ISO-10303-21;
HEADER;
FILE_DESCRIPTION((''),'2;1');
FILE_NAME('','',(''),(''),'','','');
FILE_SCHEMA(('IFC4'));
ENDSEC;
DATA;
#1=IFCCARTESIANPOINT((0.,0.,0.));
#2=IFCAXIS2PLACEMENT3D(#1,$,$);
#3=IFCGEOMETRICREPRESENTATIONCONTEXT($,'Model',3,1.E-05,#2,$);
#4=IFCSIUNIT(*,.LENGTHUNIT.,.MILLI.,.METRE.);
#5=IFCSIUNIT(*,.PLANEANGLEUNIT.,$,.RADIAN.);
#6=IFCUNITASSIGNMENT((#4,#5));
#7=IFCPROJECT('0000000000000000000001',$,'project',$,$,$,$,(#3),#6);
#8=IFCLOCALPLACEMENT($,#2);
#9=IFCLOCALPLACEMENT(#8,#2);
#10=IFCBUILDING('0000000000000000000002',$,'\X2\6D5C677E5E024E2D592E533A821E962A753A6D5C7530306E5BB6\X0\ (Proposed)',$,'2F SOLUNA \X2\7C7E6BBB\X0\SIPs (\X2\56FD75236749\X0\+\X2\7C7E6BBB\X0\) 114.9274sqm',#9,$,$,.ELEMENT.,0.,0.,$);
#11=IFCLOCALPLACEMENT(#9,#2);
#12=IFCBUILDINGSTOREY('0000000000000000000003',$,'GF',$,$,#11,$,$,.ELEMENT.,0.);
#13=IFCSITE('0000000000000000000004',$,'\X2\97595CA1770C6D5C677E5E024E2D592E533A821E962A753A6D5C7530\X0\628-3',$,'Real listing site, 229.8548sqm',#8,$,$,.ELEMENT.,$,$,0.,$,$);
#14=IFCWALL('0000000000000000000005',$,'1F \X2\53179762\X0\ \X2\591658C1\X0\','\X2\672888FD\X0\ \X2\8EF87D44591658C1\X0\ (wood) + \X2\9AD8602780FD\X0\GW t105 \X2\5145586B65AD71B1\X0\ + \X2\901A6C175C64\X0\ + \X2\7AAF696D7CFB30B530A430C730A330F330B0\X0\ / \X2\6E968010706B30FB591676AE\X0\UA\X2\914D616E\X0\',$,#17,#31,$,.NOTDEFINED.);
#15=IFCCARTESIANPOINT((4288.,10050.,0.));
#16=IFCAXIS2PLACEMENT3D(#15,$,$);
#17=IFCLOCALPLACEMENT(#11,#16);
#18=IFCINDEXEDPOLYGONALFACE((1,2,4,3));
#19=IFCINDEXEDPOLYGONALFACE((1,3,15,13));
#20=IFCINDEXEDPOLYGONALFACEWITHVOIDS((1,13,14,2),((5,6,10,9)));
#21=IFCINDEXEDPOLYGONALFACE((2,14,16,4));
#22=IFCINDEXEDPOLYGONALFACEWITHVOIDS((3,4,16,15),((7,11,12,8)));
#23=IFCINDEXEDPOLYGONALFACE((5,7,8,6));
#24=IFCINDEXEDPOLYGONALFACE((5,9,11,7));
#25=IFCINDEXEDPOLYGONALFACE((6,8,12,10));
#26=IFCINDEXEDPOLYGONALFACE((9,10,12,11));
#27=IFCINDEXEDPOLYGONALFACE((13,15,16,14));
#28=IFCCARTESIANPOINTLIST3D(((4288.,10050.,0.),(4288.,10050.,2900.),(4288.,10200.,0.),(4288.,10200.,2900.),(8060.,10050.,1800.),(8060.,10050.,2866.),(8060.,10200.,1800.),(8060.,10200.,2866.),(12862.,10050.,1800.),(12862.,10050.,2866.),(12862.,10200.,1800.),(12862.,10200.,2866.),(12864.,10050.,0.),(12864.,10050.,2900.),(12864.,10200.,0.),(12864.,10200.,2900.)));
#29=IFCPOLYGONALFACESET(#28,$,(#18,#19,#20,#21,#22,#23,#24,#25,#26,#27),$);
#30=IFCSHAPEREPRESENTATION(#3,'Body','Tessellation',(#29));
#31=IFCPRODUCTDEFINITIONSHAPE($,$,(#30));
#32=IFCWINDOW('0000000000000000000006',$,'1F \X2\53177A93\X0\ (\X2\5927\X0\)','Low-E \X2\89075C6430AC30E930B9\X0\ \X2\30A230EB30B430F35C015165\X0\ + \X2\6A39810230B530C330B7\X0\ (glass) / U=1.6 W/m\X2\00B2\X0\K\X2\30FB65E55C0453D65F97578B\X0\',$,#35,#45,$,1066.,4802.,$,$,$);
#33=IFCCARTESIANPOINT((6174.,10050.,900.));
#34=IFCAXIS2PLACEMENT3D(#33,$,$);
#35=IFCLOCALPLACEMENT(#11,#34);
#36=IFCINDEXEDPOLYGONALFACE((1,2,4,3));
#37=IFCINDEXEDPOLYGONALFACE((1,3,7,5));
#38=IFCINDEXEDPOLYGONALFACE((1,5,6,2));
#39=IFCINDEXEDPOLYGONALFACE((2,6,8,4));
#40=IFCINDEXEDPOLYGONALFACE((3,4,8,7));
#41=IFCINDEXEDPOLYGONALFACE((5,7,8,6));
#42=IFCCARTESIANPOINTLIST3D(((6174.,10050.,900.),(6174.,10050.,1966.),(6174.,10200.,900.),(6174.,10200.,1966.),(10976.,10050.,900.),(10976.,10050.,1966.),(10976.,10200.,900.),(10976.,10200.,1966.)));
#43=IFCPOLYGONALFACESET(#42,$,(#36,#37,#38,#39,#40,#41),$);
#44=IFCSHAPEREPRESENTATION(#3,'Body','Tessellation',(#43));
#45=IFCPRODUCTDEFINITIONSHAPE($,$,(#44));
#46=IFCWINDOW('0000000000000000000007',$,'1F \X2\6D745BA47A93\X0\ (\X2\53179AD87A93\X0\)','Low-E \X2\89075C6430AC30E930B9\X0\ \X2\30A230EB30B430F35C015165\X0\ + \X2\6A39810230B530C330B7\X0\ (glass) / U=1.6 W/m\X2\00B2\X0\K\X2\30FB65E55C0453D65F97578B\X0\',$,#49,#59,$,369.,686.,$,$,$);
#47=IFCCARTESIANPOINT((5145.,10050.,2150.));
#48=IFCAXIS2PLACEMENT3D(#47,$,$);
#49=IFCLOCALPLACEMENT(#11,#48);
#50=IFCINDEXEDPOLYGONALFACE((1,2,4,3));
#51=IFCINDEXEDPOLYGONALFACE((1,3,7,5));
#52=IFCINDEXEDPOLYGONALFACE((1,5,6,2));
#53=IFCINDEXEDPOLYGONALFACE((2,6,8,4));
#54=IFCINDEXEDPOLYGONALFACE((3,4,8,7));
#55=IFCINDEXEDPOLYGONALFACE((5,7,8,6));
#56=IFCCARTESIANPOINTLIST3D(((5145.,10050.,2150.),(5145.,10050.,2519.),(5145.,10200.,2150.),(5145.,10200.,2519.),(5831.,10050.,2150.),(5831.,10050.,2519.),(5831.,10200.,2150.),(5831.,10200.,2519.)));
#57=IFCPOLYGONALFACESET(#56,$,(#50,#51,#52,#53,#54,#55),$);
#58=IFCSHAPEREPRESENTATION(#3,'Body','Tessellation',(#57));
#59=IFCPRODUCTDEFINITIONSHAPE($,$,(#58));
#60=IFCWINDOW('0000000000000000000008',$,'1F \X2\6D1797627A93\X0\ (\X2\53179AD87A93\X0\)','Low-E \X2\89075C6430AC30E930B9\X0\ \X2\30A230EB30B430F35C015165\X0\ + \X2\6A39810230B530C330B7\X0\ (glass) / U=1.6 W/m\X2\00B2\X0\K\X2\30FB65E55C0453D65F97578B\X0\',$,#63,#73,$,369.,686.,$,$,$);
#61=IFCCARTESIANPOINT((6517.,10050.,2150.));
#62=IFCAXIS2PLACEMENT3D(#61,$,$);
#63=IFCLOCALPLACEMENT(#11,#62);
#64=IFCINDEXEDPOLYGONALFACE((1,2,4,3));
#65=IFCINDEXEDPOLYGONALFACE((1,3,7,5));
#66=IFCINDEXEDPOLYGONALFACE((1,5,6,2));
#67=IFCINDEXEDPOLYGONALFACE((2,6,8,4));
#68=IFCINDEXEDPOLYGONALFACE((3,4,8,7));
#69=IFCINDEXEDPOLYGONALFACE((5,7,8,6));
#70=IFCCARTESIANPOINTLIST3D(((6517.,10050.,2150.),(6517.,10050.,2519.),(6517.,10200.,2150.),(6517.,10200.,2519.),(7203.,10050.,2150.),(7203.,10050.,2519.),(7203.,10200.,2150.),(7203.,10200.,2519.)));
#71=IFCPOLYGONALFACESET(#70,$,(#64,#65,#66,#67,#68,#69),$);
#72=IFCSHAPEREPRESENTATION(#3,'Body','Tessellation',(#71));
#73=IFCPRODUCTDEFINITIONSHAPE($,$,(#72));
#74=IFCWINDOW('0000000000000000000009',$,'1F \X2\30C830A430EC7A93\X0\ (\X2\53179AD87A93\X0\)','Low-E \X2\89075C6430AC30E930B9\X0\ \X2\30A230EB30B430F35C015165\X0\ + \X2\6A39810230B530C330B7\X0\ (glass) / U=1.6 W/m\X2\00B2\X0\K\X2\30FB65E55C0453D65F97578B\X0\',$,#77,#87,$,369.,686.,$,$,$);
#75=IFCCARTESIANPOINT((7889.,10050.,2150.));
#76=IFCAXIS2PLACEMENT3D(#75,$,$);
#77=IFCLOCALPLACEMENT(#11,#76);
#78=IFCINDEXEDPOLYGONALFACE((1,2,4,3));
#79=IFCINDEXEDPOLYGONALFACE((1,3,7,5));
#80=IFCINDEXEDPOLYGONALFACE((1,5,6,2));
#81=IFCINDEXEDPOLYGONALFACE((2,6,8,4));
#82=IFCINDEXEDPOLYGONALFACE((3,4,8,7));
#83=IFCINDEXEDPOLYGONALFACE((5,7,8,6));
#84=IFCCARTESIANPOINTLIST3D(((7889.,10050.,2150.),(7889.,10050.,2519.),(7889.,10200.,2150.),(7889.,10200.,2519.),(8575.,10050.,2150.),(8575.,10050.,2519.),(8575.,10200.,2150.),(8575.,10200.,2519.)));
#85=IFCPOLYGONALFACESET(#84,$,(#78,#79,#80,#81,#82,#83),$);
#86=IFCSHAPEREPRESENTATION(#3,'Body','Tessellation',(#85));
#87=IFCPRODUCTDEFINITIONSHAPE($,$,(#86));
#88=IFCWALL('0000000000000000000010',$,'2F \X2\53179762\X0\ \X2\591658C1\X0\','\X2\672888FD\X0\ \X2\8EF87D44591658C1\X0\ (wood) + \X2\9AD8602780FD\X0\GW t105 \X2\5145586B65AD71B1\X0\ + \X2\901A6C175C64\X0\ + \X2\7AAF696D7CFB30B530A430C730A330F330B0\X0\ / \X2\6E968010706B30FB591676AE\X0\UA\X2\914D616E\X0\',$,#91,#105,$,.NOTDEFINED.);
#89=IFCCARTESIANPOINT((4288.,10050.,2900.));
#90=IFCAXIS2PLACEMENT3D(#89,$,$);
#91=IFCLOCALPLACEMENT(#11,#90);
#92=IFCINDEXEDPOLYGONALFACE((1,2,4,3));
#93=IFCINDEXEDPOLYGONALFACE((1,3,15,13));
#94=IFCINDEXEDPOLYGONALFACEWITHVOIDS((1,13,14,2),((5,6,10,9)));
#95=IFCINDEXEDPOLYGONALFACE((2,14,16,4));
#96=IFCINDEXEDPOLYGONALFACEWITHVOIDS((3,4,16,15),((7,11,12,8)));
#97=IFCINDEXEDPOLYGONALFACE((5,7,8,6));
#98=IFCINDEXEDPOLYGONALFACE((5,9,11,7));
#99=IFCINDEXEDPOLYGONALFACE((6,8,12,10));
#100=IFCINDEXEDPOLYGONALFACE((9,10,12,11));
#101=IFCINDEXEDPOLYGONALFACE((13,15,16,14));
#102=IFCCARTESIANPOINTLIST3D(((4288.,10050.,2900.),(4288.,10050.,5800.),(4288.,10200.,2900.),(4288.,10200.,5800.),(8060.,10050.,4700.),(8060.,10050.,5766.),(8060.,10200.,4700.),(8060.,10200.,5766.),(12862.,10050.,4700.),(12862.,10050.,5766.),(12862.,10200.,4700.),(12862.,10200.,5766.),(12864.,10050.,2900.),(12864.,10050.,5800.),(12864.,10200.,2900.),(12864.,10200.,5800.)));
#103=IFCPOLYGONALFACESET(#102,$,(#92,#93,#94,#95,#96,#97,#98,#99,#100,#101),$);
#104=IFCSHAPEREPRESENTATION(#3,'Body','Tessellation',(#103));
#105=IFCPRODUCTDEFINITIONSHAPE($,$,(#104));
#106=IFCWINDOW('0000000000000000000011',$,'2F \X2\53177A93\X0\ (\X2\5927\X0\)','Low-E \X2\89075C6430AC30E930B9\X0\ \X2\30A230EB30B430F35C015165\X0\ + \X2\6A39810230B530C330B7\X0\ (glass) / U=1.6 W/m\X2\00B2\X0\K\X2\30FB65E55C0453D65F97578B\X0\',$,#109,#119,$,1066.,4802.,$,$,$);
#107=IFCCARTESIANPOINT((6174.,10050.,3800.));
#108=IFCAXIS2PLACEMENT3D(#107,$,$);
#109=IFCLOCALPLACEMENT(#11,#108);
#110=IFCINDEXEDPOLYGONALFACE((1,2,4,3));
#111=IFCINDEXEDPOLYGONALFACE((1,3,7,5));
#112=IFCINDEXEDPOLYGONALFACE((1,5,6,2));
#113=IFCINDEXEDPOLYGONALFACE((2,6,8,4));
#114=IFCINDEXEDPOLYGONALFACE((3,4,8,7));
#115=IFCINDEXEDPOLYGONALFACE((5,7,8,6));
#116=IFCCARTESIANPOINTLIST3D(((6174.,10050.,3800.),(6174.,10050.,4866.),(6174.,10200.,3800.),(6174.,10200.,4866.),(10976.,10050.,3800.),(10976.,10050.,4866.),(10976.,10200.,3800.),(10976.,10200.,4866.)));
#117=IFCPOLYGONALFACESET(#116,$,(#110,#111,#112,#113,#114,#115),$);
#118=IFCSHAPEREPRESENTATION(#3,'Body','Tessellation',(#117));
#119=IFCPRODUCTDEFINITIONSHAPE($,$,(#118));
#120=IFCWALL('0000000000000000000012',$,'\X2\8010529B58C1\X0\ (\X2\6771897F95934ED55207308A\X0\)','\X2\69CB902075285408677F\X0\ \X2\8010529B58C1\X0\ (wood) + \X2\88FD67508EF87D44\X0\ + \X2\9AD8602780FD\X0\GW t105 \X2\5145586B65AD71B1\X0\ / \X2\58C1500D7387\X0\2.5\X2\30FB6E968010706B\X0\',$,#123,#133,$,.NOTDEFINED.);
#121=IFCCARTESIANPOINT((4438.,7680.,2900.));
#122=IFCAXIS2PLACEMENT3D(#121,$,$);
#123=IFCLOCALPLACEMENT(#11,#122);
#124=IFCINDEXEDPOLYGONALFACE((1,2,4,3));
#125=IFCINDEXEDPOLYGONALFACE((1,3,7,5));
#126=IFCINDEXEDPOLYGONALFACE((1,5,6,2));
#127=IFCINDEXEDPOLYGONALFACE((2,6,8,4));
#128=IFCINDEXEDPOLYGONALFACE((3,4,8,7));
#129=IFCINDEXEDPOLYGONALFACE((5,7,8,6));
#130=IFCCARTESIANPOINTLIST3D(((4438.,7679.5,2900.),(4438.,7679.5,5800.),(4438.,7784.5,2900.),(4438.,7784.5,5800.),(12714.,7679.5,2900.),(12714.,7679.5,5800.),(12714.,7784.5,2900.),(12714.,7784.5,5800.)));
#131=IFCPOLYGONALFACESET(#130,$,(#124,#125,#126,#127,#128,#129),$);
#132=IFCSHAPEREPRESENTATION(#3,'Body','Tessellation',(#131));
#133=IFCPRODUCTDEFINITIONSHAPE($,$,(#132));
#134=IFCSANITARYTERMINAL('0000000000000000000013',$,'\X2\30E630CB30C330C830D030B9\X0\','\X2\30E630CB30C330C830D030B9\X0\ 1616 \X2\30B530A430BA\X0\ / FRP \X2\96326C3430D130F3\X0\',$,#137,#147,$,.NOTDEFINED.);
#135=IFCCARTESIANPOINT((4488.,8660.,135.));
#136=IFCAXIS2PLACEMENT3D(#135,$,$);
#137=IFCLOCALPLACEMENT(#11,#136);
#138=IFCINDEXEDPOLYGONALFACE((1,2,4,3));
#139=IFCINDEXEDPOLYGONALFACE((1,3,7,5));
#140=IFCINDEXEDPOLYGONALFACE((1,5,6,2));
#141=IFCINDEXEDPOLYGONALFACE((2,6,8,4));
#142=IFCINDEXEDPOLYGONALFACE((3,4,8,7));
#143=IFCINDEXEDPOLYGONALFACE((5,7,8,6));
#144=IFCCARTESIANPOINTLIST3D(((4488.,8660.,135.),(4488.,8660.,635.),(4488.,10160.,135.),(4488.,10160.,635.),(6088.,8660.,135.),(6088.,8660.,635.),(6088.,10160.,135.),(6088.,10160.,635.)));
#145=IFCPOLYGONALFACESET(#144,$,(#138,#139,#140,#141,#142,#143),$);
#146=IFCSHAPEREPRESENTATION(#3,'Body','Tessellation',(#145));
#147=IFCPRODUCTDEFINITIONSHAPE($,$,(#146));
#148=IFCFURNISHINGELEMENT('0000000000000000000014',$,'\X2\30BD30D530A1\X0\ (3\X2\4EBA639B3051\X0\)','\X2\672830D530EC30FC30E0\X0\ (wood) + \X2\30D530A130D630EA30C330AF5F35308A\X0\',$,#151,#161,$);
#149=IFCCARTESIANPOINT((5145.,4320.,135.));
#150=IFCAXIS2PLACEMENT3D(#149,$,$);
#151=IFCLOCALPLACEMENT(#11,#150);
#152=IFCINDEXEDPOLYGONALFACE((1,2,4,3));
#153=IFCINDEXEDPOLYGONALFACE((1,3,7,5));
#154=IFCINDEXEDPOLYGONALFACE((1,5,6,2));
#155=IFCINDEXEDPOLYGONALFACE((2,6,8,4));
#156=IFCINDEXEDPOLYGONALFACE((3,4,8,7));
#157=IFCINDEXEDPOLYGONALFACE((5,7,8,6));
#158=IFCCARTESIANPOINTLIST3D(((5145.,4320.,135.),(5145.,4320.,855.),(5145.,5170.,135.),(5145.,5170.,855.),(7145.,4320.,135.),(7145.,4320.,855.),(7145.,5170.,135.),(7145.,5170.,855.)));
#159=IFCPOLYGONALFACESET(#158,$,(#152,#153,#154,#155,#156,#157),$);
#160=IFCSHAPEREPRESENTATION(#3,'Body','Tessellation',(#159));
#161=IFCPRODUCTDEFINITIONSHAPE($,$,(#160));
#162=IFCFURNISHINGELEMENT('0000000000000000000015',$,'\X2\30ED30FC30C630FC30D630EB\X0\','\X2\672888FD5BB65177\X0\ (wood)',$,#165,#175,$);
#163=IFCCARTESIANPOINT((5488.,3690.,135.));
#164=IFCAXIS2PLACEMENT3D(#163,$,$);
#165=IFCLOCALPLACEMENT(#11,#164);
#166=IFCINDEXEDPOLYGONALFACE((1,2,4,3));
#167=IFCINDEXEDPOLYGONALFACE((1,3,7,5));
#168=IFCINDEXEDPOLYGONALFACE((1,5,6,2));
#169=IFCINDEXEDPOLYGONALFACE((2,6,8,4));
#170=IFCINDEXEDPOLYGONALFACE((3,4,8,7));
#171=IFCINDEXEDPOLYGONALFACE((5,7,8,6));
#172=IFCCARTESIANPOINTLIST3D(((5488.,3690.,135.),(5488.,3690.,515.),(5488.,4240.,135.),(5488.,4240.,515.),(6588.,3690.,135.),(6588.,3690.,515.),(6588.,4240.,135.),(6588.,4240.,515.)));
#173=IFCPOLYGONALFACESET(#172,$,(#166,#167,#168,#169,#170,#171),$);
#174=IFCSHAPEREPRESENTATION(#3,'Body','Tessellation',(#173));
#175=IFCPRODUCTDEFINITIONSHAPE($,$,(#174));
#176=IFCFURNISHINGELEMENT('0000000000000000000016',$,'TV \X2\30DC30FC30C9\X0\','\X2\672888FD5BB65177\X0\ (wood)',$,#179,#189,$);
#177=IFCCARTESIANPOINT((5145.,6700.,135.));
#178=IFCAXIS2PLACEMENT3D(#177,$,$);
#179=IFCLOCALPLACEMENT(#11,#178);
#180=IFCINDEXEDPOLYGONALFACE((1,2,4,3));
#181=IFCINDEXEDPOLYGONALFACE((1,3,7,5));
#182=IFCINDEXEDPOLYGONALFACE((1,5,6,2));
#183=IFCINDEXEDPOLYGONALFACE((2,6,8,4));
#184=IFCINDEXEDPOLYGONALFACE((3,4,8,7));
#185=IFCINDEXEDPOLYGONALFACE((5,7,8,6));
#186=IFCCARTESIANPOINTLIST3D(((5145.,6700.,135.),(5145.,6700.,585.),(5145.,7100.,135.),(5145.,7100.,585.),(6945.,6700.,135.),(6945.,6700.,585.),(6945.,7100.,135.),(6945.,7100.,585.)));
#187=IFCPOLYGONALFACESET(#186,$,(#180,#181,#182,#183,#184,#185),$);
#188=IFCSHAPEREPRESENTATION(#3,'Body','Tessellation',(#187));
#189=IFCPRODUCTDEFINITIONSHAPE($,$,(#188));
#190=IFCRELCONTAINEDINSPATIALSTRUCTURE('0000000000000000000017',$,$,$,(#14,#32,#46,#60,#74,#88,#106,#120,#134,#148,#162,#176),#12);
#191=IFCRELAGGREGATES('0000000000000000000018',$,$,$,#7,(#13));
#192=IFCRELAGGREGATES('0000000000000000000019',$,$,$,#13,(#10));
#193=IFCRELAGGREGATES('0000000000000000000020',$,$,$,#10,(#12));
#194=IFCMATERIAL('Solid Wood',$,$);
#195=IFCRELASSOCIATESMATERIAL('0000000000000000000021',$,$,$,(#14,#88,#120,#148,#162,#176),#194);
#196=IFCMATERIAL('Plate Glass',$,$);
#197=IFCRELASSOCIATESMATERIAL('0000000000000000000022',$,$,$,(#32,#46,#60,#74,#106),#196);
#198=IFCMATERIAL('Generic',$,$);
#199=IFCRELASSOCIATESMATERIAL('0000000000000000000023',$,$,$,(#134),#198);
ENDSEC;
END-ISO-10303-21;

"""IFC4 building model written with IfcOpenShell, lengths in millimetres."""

from ifc_helpers import new_model, si_unit, frame, frame_2d, origin, place, context, project, spatial, rectangle, extrude, material, element, fill, save


model = new_model("IFC4")

# Units and contexts
model_context = context("Model", 3, precision=1e-05, world=origin())
ifc_project = project(units=[si_unit("LENGTHUNIT", "METRE", prefix="MILLI"), si_unit("PLANEANGLEUNIT", "RADIAN")], contexts=[model_context])

# Site, building, storey
site_placement = place(None, origin())
site = spatial("IfcSite", under=ifc_project, at=site_placement, Name="静岡県浜松市中央区舞阪町浜田628-3", ObjectType="Real listing site, 229.8548sqm", CompositionType="ELEMENT", RefElevation=0.0)
building_placement = place(site_placement, origin())
building = spatial("IfcBuilding", under=site, at=building_placement, Name="浜松市中央区舞阪町浜田の家 (Proposed)", ObjectType="2F SOLUNA 籾殻SIPs (国産杉+籾殻) 114.9274sqm", CompositionType="ELEMENT", ElevationOfRefHeight=0.0, ElevationOfTerrain=0.0)
storey_placement = place(building_placement, origin())
storey = spatial("IfcBuildingStorey", under=building, at=storey_placement, Name="GF", CompositionType="ELEMENT", Elevation=0.0)

# Wall, openings, windows
ifc_material_1 = material(Name="Solid Wood")
wall_1_placement = place(storey_placement, frame((4288.0, 10050.0, 0.0)))
wall_1 = element("IfcWall", 1, at=wall_1_placement, inside=storey, material=ifc_material_1, Name="1F 北面 外壁", Description="木製 軸組外壁 (wood) + 高性能GW t105 充填断熱 + 通気層 + 窯業系サイディング / 準耐火・外皮UA配慮", PredefinedType="NOTDEFINED", context=model_context, shape_type="SweptSolid", body=[
    extrude(rectangle(XDim=8576.0, YDim=150.0, at=frame_2d((4288.0, 75.0))), frame((4288.0, 10050.0, 0.0)), (0.0, 0.0, 1.0), 2900.0),
])
opening_1_placement = place(storey_placement, frame((6174.0, 10050.0, 900.0)))
opening_1 = element("IfcOpeningElement", 2, at=opening_1_placement, cuts=wall_1, PredefinedType="NOTDEFINED", context=model_context, shape_type="SweptSolid", body=[
    extrude(rectangle(XDim=4802.0, YDim=150.0, at=frame_2d((2401.0, 75.0))), frame((6174.0, 10050.0, 900.0)), (0.0, 0.0, 1.0), 1066.0),
])
opening_2_placement = place(storey_placement, frame((5145.0, 10050.0, 2150.0)))
opening_2 = element("IfcOpeningElement", 3, at=opening_2_placement, cuts=wall_1, PredefinedType="NOTDEFINED", context=model_context, shape_type="SweptSolid", body=[
    extrude(rectangle(XDim=686.0, YDim=150.0, at=frame_2d((343.0, 75.0))), frame((5145.0, 10050.0, 2150.0)), (0.0, 0.0, 1.0), 369.0),
])
opening_3_placement = place(storey_placement, frame((6517.0, 10050.0, 2150.0)))
opening_3 = element("IfcOpeningElement", 4, at=opening_3_placement, cuts=wall_1, PredefinedType="NOTDEFINED", context=model_context, shape_type="SweptSolid", body=[
    extrude(rectangle(XDim=686.0, YDim=150.0, at=frame_2d((343.0, 75.0))), frame((6517.0, 10050.0, 2150.0)), (0.0, 0.0, 1.0), 369.0),
])
opening_4_placement = place(storey_placement, frame((7889.0, 10050.0, 2150.0)))
opening_4 = element("IfcOpeningElement", 5, at=opening_4_placement, cuts=wall_1, PredefinedType="NOTDEFINED", context=model_context, shape_type="SweptSolid", body=[
    extrude(rectangle(XDim=686.0, YDim=150.0, at=frame_2d((343.0, 75.0))), frame((7889.0, 10050.0, 2150.0)), (0.0, 0.0, 1.0), 369.0),
])
ifc_material_2 = material(Name="Plate Glass")
window_1_placement = place(storey_placement, frame((6174.0, 10050.0, 900.0)))
window_1 = element("IfcWindow", 6, at=window_1_placement, inside=storey, material=ifc_material_2, Name="1F 北窓 (大)", Description="Low-E 複層ガラス アルゴン封入 + 樹脂サッシ (glass) / U=1.6 W/m²K・日射取得型", OverallHeight=1066.0, OverallWidth=4802.0, context=model_context, shape_type="SweptSolid", body=[
    extrude(rectangle(XDim=4802.0, YDim=150.0, at=frame_2d((2401.0, 75.0))), frame((6174.0, 10050.0, 900.0)), (0.0, 0.0, 1.0), 1066.0),
])
fill(opening_1, window_1)
window_2_placement = place(storey_placement, frame((5145.0, 10050.0, 2150.0)))
window_2 = element("IfcWindow", 7, at=window_2_placement, inside=storey, material=ifc_material_2, Name="1F 浴室窓 (北高窓)", Description="Low-E 複層ガラス アルゴン封入 + 樹脂サッシ (glass) / U=1.6 W/m²K・日射取得型", OverallHeight=369.0, OverallWidth=686.0, context=model_context, shape_type="SweptSolid", body=[
    extrude(rectangle(XDim=686.0, YDim=150.0, at=frame_2d((343.0, 75.0))), frame((5145.0, 10050.0, 2150.0)), (0.0, 0.0, 1.0), 369.0),
])
fill(opening_2, window_2)
window_3_placement = place(storey_placement, frame((6517.0, 10050.0, 2150.0)))
window_3 = element("IfcWindow", 8, at=window_3_placement, inside=storey, material=ifc_material_2, Name="1F 洗面窓 (北高窓)", Description="Low-E 複層ガラス アルゴン封入 + 樹脂サッシ (glass) / U=1.6 W/m²K・日射取得型", OverallHeight=369.0, OverallWidth=686.0, context=model_context, shape_type="SweptSolid", body=[
    extrude(rectangle(XDim=686.0, YDim=150.0, at=frame_2d((343.0, 75.0))), frame((6517.0, 10050.0, 2150.0)), (0.0, 0.0, 1.0), 369.0),
])
fill(opening_3, window_3)
window_4_placement = place(storey_placement, frame((7889.0, 10050.0, 2150.0)))
window_4 = element("IfcWindow", 9, at=window_4_placement, inside=storey, material=ifc_material_2, Name="1F トイレ窓 (北高窓)", Description="Low-E 複層ガラス アルゴン封入 + 樹脂サッシ (glass) / U=1.6 W/m²K・日射取得型", OverallHeight=369.0, OverallWidth=686.0, context=model_context, shape_type="SweptSolid", body=[
    extrude(rectangle(XDim=686.0, YDim=150.0, at=frame_2d((343.0, 75.0))), frame((7889.0, 10050.0, 2150.0)), (0.0, 0.0, 1.0), 369.0),
])
fill(opening_4, window_4)

# Wall, opening, window
wall_2_placement = place(storey_placement, frame((4288.0, 10050.0, 2900.0)))
wall_2 = element("IfcWall", 10, at=wall_2_placement, inside=storey, material=ifc_material_1, Name="2F 北面 外壁", Description="木製 軸組外壁 (wood) + 高性能GW t105 充填断熱 + 通気層 + 窯業系サイディング / 準耐火・外皮UA配慮", PredefinedType="NOTDEFINED", context=model_context, shape_type="SweptSolid", body=[
    extrude(rectangle(XDim=8576.0, YDim=150.0, at=frame_2d((4288.0, 75.0))), frame((4288.0, 10050.0, 2900.0)), (0.0, 0.0, 1.0), 2900.0),
])
opening_5_placement = place(storey_placement, frame((6174.0, 10050.0, 3800.0)))
opening_5 = element("IfcOpeningElement", 11, at=opening_5_placement, cuts=wall_2, PredefinedType="NOTDEFINED", context=model_context, shape_type="SweptSolid", body=[
    extrude(rectangle(XDim=4802.0, YDim=150.0, at=frame_2d((2401.0, 75.0))), frame((6174.0, 10050.0, 3800.0)), (0.0, 0.0, 1.0), 1066.0),
])
window_5_placement = place(storey_placement, frame((6174.0, 10050.0, 3800.0)))
window_5 = element("IfcWindow", 12, at=window_5_placement, inside=storey, material=ifc_material_2, Name="2F 北窓 (大)", Description="Low-E 複層ガラス アルゴン封入 + 樹脂サッシ (glass) / U=1.6 W/m²K・日射取得型", OverallHeight=1066.0, OverallWidth=4802.0, context=model_context, shape_type="SweptSolid", body=[
    extrude(rectangle(XDim=4802.0, YDim=150.0, at=frame_2d((2401.0, 75.0))), frame((6174.0, 10050.0, 3800.0)), (0.0, 0.0, 1.0), 1066.0),
])
fill(opening_5, window_5)

# Wall
wall_3_placement = place(storey_placement, frame((4438.0, 7680.0, 2900.0)))
element("IfcWall", 13, at=wall_3_placement, inside=storey, material=ifc_material_1, Name="耐力壁 (東西間仕切り)", Description="構造用合板 耐力壁 (wood) + 製材軸組 + 高性能GW t105 充填断熱 / 壁倍率2.5・準耐火", PredefinedType="NOTDEFINED", context=model_context, shape_type="SweptSolid", body=[
    extrude(rectangle(XDim=8276.0, YDim=105.0, at=frame_2d((4138.0, 52.0))), frame((4438.0, 7680.0, 2900.0)), (0.0, 0.0, 1.0), 2900.0),
])

# Sanitary terminal
ifc_material_3 = material(Name="Generic")
sanitary_terminal_placement = place(storey_placement, frame((4488.0, 8660.0, 135.0)))
element("IfcSanitaryTerminal", 14, at=sanitary_terminal_placement, inside=storey, material=ifc_material_3, Name="ユニットバス", Description="ユニットバス 1616 サイズ / FRP 防水パン", PredefinedType="NOTDEFINED", context=model_context, shape_type="SweptSolid", body=[
    extrude(rectangle(XDim=1600.0, YDim=1500.0, at=frame_2d((800.0, 750.0))), frame((4488.0, 8660.0, 135.0)), (0.0, 0.0, 1.0), 500.0),
])

# Furnishing elements
furnishing_1_placement = place(storey_placement, frame((5145.0, 4320.0, 135.0)))
element("IfcFurnishingElement", 15, at=furnishing_1_placement, inside=storey, material=ifc_material_1, Name="ソファ (3人掛け)", Description="木フレーム (wood) + ファブリック張り", context=model_context, shape_type="SweptSolid", body=[
    extrude(rectangle(XDim=2000.0, YDim=850.0, at=frame_2d((1000.0, 425.0))), frame((5145.0, 4320.0, 135.0)), (0.0, 0.0, 1.0), 720.0),
])
furnishing_2_placement = place(storey_placement, frame((5488.0, 3690.0, 135.0)))
element("IfcFurnishingElement", 16, at=furnishing_2_placement, inside=storey, material=ifc_material_1, Name="ローテーブル", Description="木製家具 (wood)", context=model_context, shape_type="SweptSolid", body=[
    extrude(rectangle(XDim=1100.0, YDim=550.0, at=frame_2d((550.0, 275.0))), frame((5488.0, 3690.0, 135.0)), (0.0, 0.0, 1.0), 380.0),
])
furnishing_3_placement = place(storey_placement, frame((5145.0, 6700.0, 135.0)))
element("IfcFurnishingElement", 17, at=furnishing_3_placement, inside=storey, material=ifc_material_1, Name="TV ボード", Description="木製家具 (wood)", context=model_context, shape_type="SweptSolid", body=[
    extrude(rectangle(XDim=1800.0, YDim=400.0, at=frame_2d((900.0, 200.0))), frame((5145.0, 6700.0, 135.0)), (0.0, 0.0, 1.0), 450.0),
])

save(model, "model.ifc")
